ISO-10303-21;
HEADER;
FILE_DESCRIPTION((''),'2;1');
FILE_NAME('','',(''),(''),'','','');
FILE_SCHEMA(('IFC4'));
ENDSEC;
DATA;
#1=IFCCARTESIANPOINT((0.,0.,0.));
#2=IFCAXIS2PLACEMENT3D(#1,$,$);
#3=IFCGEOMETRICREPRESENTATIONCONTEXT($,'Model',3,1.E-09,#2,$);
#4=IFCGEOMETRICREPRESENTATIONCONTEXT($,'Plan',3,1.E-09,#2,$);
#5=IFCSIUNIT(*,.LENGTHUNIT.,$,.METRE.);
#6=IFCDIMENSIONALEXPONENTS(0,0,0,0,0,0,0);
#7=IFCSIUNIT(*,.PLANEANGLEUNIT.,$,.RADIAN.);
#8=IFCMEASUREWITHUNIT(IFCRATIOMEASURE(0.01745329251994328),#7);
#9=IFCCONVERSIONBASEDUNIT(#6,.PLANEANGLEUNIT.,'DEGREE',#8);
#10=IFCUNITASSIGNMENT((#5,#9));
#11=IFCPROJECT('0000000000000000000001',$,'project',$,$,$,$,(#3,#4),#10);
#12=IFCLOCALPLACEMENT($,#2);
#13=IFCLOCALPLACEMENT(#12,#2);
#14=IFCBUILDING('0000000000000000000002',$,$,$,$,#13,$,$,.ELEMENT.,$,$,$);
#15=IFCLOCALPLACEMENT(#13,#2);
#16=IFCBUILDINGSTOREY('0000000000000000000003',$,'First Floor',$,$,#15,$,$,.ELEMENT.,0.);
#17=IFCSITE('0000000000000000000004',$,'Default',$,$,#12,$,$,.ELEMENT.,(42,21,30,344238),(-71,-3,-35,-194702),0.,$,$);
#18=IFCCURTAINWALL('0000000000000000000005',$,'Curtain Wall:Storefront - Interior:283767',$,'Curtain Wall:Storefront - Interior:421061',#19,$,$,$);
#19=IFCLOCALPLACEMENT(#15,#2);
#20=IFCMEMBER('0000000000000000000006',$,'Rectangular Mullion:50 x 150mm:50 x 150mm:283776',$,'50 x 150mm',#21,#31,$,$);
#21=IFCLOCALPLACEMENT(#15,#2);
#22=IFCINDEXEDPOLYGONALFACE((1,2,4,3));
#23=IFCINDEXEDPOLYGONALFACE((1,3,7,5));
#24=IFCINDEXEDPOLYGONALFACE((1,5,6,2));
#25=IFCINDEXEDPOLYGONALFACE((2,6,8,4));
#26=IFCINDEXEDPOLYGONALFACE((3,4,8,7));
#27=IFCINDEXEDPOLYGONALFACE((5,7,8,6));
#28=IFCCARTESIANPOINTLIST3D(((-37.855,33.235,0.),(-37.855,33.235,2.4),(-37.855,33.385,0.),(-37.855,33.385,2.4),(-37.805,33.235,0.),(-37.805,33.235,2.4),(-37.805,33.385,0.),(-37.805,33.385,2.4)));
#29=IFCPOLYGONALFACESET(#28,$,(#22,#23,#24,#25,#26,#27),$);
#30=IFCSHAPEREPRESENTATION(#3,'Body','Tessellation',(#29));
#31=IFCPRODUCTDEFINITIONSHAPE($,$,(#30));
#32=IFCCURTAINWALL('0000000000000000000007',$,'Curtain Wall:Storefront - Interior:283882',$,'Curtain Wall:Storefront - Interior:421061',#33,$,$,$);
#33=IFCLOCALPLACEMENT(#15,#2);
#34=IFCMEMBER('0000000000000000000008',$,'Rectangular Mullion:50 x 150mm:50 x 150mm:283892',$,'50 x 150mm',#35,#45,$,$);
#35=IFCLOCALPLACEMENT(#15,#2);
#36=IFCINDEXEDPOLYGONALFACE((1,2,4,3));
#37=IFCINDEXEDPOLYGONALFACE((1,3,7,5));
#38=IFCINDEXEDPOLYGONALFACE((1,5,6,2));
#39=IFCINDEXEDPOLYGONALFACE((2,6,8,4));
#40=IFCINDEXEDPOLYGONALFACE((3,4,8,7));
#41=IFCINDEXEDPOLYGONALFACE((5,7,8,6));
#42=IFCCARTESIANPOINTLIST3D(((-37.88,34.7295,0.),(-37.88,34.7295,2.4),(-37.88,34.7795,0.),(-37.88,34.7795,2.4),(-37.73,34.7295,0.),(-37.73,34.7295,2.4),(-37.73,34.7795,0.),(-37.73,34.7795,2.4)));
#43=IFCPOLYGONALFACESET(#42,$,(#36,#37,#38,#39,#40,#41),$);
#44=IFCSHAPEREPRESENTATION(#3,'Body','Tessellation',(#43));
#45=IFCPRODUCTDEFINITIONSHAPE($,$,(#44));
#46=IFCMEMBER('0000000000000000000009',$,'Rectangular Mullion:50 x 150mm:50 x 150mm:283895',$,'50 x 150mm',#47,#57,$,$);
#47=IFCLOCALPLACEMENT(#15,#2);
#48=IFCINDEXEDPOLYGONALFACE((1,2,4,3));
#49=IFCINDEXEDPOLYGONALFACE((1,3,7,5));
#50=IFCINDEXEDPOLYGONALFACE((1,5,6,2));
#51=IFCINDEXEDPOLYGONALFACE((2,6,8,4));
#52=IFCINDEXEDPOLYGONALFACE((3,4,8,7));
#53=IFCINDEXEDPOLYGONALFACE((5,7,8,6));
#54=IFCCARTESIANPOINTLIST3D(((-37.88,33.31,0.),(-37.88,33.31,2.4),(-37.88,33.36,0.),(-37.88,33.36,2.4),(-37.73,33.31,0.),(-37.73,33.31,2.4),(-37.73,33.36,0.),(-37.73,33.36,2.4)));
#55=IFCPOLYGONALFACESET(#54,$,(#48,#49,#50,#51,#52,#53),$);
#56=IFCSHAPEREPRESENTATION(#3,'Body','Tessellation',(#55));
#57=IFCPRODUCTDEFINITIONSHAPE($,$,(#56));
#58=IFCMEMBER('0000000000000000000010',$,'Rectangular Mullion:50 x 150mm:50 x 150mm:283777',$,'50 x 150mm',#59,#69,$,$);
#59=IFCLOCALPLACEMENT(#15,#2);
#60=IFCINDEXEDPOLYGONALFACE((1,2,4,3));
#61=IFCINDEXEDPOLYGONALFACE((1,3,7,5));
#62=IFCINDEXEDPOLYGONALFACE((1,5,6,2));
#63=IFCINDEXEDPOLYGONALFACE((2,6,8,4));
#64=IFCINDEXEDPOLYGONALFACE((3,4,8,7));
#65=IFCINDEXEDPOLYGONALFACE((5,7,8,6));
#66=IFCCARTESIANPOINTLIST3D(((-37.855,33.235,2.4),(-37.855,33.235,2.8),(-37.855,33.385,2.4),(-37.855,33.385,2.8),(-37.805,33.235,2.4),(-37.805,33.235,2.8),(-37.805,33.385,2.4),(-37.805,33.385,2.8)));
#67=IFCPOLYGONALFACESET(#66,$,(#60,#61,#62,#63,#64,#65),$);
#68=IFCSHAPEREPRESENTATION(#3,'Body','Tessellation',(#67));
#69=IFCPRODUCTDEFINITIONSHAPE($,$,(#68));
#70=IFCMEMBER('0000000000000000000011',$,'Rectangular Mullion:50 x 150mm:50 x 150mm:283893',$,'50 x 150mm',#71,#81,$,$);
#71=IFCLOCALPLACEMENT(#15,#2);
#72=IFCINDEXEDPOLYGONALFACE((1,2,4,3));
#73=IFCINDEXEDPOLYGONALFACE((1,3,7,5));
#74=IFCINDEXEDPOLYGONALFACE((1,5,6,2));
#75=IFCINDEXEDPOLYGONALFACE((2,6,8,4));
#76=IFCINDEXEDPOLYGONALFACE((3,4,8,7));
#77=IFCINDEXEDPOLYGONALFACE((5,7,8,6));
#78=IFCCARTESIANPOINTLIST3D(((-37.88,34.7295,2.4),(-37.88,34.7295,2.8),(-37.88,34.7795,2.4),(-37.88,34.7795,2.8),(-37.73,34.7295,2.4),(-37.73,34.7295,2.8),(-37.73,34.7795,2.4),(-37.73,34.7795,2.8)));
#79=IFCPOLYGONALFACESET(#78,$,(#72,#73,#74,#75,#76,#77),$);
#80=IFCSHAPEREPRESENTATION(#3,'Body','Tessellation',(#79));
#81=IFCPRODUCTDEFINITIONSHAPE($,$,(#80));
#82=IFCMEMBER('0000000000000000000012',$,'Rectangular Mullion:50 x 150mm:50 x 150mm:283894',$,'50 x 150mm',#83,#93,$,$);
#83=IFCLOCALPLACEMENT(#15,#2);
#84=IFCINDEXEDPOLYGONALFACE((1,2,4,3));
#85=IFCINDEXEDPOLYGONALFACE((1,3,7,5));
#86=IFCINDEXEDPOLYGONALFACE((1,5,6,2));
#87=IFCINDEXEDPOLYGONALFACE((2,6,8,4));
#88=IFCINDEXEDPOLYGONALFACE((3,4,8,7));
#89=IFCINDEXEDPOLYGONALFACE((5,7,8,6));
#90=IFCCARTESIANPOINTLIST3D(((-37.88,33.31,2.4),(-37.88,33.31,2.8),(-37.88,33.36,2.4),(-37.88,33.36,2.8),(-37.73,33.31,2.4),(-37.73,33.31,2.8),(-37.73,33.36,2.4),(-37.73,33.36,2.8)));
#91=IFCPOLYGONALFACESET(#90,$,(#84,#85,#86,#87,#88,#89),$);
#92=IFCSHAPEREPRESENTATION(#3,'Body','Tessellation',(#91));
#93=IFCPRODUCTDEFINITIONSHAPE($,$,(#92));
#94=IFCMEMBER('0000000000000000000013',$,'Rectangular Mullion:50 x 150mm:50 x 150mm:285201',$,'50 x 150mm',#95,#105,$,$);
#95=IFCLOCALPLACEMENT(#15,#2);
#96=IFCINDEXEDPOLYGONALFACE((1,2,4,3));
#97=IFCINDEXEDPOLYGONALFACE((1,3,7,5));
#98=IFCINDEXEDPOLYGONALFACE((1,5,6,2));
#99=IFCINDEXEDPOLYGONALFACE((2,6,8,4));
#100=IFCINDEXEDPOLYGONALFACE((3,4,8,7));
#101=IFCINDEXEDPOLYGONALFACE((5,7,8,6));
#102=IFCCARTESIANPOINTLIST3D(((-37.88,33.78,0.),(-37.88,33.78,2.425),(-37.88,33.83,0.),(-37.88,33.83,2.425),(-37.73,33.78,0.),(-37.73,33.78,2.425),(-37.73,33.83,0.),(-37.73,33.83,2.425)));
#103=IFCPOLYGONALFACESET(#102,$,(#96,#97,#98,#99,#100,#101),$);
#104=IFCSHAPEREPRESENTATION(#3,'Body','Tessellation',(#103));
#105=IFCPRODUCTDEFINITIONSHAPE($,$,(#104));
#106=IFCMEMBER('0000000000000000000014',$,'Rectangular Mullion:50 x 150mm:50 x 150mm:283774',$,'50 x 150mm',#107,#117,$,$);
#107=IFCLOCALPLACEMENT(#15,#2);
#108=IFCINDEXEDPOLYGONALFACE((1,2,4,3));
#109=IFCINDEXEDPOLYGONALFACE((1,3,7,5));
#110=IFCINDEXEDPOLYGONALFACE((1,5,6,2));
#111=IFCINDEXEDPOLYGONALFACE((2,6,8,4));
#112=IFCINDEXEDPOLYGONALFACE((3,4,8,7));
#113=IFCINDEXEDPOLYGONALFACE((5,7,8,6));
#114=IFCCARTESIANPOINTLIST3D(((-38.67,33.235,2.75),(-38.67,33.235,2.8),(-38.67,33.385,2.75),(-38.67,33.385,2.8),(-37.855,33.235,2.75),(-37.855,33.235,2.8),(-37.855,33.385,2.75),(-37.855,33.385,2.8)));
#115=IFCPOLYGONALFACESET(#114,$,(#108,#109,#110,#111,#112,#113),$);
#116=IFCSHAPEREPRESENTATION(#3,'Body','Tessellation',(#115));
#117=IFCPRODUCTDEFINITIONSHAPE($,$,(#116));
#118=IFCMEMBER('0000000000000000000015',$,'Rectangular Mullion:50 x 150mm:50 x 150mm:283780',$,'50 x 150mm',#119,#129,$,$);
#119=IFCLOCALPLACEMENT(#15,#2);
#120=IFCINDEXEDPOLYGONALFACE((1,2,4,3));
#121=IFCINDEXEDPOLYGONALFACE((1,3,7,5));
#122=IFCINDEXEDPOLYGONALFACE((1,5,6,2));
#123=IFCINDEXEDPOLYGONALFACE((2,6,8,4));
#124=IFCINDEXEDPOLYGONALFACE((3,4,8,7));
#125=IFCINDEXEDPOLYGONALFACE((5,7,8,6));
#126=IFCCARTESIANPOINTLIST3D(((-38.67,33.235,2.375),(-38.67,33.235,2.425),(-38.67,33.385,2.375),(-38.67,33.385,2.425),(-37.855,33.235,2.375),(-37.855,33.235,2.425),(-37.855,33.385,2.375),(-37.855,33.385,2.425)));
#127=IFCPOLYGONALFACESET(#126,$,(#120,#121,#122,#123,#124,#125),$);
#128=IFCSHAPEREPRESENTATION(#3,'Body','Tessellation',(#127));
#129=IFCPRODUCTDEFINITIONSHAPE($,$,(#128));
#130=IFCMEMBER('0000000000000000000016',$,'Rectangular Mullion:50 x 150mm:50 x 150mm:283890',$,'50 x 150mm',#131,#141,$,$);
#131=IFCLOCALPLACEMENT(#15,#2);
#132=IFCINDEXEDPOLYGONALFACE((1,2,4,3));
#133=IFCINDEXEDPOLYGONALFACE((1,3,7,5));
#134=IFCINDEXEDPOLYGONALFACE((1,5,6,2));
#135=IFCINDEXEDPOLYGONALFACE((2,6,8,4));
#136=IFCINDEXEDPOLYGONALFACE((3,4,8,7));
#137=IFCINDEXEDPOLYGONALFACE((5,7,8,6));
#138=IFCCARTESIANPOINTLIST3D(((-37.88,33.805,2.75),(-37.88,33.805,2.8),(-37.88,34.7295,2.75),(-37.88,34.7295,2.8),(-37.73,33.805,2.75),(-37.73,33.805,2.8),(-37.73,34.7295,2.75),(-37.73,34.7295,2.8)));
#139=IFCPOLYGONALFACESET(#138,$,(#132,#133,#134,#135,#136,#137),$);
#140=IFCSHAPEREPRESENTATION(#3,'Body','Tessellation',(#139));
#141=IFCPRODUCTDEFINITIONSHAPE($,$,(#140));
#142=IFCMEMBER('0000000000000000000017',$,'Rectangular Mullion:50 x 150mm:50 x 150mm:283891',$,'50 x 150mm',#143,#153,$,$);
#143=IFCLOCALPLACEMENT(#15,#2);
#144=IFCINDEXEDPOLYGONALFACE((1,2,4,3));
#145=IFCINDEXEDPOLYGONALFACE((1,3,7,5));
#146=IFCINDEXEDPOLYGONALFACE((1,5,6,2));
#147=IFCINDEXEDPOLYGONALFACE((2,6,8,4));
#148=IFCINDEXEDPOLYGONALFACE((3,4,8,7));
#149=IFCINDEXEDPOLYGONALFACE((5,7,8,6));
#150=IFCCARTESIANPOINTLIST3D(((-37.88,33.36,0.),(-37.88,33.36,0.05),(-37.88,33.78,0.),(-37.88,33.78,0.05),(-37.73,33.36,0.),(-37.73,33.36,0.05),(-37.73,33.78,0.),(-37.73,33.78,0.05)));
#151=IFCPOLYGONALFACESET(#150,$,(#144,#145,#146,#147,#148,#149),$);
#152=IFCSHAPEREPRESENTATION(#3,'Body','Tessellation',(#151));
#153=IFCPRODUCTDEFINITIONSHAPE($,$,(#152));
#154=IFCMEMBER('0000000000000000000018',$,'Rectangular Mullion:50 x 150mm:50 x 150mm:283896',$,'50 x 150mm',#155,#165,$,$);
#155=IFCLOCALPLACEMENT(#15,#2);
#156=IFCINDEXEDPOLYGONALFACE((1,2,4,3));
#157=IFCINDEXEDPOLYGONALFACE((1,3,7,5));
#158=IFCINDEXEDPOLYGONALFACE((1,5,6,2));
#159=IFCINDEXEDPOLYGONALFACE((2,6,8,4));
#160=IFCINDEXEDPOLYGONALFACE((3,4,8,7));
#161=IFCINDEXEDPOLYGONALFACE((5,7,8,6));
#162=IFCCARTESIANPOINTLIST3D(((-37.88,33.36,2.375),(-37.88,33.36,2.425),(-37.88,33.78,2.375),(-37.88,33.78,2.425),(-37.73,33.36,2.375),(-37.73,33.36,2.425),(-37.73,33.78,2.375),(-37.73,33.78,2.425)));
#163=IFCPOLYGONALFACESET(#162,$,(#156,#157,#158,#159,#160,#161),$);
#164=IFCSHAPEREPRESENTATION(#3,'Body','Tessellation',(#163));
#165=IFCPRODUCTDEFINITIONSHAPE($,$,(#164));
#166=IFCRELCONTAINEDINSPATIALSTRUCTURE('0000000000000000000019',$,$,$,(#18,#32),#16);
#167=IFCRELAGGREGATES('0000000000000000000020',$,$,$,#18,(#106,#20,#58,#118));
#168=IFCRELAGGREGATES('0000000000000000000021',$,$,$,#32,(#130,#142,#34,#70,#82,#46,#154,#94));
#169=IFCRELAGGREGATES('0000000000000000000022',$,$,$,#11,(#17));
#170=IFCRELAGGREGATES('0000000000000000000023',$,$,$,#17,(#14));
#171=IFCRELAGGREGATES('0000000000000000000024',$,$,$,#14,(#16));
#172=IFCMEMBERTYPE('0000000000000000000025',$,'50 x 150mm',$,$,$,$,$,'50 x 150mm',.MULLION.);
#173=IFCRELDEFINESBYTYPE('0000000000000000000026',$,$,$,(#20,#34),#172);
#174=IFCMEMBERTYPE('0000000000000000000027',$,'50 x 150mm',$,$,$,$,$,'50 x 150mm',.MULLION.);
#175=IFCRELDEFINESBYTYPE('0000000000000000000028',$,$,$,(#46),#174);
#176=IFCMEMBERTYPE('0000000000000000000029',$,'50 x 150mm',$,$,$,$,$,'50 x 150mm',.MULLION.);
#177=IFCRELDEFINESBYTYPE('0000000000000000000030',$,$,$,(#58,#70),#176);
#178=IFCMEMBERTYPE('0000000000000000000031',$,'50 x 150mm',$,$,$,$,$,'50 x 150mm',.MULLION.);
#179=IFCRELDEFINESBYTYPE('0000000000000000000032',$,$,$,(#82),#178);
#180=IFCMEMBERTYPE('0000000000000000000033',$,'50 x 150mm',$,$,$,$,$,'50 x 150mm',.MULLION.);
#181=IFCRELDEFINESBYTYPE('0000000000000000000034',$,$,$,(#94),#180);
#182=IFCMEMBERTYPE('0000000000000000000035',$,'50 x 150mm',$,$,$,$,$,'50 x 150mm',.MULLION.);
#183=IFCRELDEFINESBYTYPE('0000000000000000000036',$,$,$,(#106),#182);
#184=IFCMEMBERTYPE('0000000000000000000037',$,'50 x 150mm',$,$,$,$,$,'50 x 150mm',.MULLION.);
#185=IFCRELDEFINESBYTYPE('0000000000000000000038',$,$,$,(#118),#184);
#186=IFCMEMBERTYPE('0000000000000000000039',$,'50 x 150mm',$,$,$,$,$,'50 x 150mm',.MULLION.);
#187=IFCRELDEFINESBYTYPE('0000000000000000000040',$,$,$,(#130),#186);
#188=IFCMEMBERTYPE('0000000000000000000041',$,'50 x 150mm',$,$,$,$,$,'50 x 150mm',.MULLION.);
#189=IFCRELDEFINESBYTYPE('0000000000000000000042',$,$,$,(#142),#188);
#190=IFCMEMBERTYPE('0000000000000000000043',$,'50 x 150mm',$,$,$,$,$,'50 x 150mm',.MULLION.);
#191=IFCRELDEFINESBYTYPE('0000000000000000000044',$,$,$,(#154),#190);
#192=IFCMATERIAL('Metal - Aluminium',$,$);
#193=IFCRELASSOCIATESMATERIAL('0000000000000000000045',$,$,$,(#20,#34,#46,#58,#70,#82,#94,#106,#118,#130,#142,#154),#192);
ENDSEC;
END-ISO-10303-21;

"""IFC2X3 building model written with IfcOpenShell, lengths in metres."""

from ifc_helpers import new_model, entity, si_unit, converted_unit, frame, origin, origin_2d_with_axis, place, context, project, spatial, rectangle, extrude, source, transform, mapped, material, type_object, type_shapes, element, aggregate, save


model = new_model("IFC2X3")

# Units and contexts
model_context = context("Model", 3, precision=1e-09, world=origin())
plan_context = context("Plan", 3, precision=1e-09, world=origin())
ifc_project = project(units=[si_unit("LENGTHUNIT", "METRE"), converted_unit("PLANEANGLEUNIT", "DEGREE", entity("IfcRatioMeasure", 0.01745329251994328), si_unit("PLANEANGLEUNIT", "RADIAN"), dimensions=[0, 0, 0, 0, 0, 0, 0])], contexts=[model_context, plan_context])

# Site, building, storey
site_placement = place(None, origin())
site = spatial("IfcSite", under=ifc_project, at=site_placement, Name="Default", CompositionType="ELEMENT", RefLatitude=(42, 21, 30, 344238), RefLongitude=(-71, -3, -35, -194702), RefElevation=0.0)
building_placement = place(site_placement, origin())
building = spatial("IfcBuilding", under=site, at=building_placement, CompositionType="ELEMENT")
storey_placement = place(building_placement, origin())
storey = spatial("IfcBuildingStorey", under=building, at=storey_placement, Name="First Floor", CompositionType="ELEMENT", Elevation=0.0)

# Curtain wall, member
curtain_wall_1_placement = place(storey_placement, origin())
curtain_wall_1 = element("IfcCurtainWall", 1, at=curtain_wall_1_placement, inside=storey, Name="Curtain Wall:Storefront - Interior:283767", ObjectType="Curtain Wall:Storefront - Interior:421061")
ifc_material_1 = material(Name="Metal - Aluminium")
member_type_1 = type_object("IfcMemberType", Name="50 x 150mm", ElementType="50 x 150mm", PredefinedType="MULLION")
shared_shape_1 = source(origin(), model_context, "Body", "SweptSolid", [
    extrude(rectangle(XDim=0.05, YDim=0.15, at=origin_2d_with_axis()), frame((-0.025, 0.0, -2.4), z_axis=(0.0, 0.0, 1.0), x_axis=(-1.0, 0.0, 0.0)), (0.0, 0.0, 1.0), 2.4),
])
type_shapes(member_type_1, [shared_shape_1])
member_1_placement = place(storey_placement, frame((-37.805, 33.31, 0.0), z_axis=(0.0, 0.0, -1.0), x_axis=(1.0, 0.0, 0.0)))
member_1 = element("IfcMember", 2, at=member_1_placement, type_object=member_type_1, material=ifc_material_1, Name="Rectangular Mullion:50 x 150mm:50 x 150mm:283776", ObjectType="50 x 150mm", context=model_context, shape_type="MappedRepresentation", body=[
    mapped(shared_shape_1, transform((0.0, 0.0, 0.0), scale=1.0)),
])

# Curtain wall, members
curtain_wall_2_placement = place(storey_placement, origin())
curtain_wall_2 = element("IfcCurtainWall", 3, at=curtain_wall_2_placement, inside=storey, Name="Curtain Wall:Storefront - Interior:283882", ObjectType="Curtain Wall:Storefront - Interior:421061")
member_2_placement = place(storey_placement, frame((-37.805, 34.7795, 0.0), z_axis=(0.0, 0.0, -1.0), x_axis=(0.0, 1.0, 0.0)))
member_2 = element("IfcMember", 4, at=member_2_placement, type_object=member_type_1, material=ifc_material_1, Name="Rectangular Mullion:50 x 150mm:50 x 150mm:283892", ObjectType="50 x 150mm", context=model_context, shape_type="MappedRepresentation", body=[
    mapped(shared_shape_1, transform((0.0, 0.0, 0.0), scale=1.0)),
])
member_type_2 = type_object("IfcMemberType", Name="50 x 150mm", ElementType="50 x 150mm", PredefinedType="MULLION")
type_shapes(member_type_2, [shared_shape_1])
member_3_placement = place(storey_placement, frame((-37.805, 33.31, 2.4), z_axis=(0.0, 0.0, 1.0), x_axis=(0.0, -1.0, 0.0)))
member_3 = element("IfcMember", 5, at=member_3_placement, type_object=member_type_2, material=ifc_material_1, Name="Rectangular Mullion:50 x 150mm:50 x 150mm:283895", ObjectType="50 x 150mm", context=model_context, shape_type="MappedRepresentation", body=[
    mapped(shared_shape_1, transform((0.0, 0.0, 0.0), scale=1.0)),
])

# Members
member_type_3 = type_object("IfcMemberType", Name="50 x 150mm", ElementType="50 x 150mm", PredefinedType="MULLION")
shared_shape_2 = source(origin(), model_context, "Body", "SweptSolid", [
    extrude(rectangle(XDim=0.05, YDim=0.15, at=origin_2d_with_axis()), frame((-0.025, 0.0, -0.4), z_axis=(0.0, 0.0, 1.0), x_axis=(-1.0, 0.0, 0.0)), (0.0, 0.0, 1.0), 0.4),
])
type_shapes(member_type_3, [shared_shape_2])
member_4_placement = place(storey_placement, frame((-37.805, 33.31, 2.4), z_axis=(0.0, 0.0, -1.0), x_axis=(1.0, 0.0, 0.0)))
member_4 = element("IfcMember", 6, at=member_4_placement, type_object=member_type_3, material=ifc_material_1, Name="Rectangular Mullion:50 x 150mm:50 x 150mm:283777", ObjectType="50 x 150mm", context=model_context, shape_type="MappedRepresentation", body=[
    mapped(shared_shape_2, transform((0.0, 0.0, 0.0), scale=1.0)),
])
member_5_placement = place(storey_placement, frame((-37.805, 34.7795, 2.4), z_axis=(0.0, 0.0, -1.0), x_axis=(0.0, 1.0, 0.0)))
member_5 = element("IfcMember", 7, at=member_5_placement, type_object=member_type_3, material=ifc_material_1, Name="Rectangular Mullion:50 x 150mm:50 x 150mm:283893", ObjectType="50 x 150mm", context=model_context, shape_type="MappedRepresentation", body=[
    mapped(shared_shape_2, transform((0.0, 0.0, 0.0), scale=1.0)),
])
member_type_4 = type_object("IfcMemberType", Name="50 x 150mm", ElementType="50 x 150mm", PredefinedType="MULLION")
type_shapes(member_type_4, [shared_shape_2])
member_6_placement = place(storey_placement, frame((-37.805, 33.31, 2.8), z_axis=(0.0, 0.0, 1.0), x_axis=(0.0, -1.0, 0.0)))
member_6 = element("IfcMember", 8, at=member_6_placement, type_object=member_type_4, material=ifc_material_1, Name="Rectangular Mullion:50 x 150mm:50 x 150mm:283894", ObjectType="50 x 150mm", context=model_context, shape_type="MappedRepresentation", body=[
    mapped(shared_shape_2, transform((0.0, 0.0, 0.0), scale=1.0)),
])
member_type_5 = type_object("IfcMemberType", Name="50 x 150mm", ElementType="50 x 150mm", PredefinedType="MULLION")
shared_shape_3 = source(origin(), model_context, "Body", "SweptSolid", [
    extrude(rectangle(XDim=0.05, YDim=0.15, at=origin_2d_with_axis()), frame((0.0, 0.0, -2.425), z_axis=(0.0, 0.0, 1.0), x_axis=(-1.0, 0.0, 0.0)), (0.0, 0.0, 1.0), 2.425),
])
type_shapes(member_type_5, [shared_shape_3])
member_7_placement = place(storey_placement, frame((-37.805, 33.805, 0.0), z_axis=(0.0, 0.0, -1.0), x_axis=(0.0, 1.0, 0.0)))
member_7 = element("IfcMember", 9, at=member_7_placement, type_object=member_type_5, material=ifc_material_1, Name="Rectangular Mullion:50 x 150mm:50 x 150mm:285201", ObjectType="50 x 150mm", context=model_context, shape_type="MappedRepresentation", body=[
    mapped(shared_shape_3, transform((0.0, 0.0, 0.0), scale=1.0)),
])
member_type_6 = type_object("IfcMemberType", Name="50 x 150mm", ElementType="50 x 150mm", PredefinedType="MULLION")
shared_shape_4 = source(origin(), model_context, "Body", "SweptSolid", [
    extrude(rectangle(XDim=0.05, YDim=0.15, at=origin_2d_with_axis()), frame((-0.025, 0.0, -0.815), z_axis=(0.0, 0.0, 1.0), x_axis=(-1.0, 0.0, 0.0)), (0.0, 0.0, 1.0), 0.815),
])
type_shapes(member_type_6, [shared_shape_4])
member_8_placement = place(storey_placement, frame((-37.855, 33.31, 2.8), z_axis=(1.0, 0.0, 0.0), x_axis=(0.0, 0.0, 1.0)))
member_8 = element("IfcMember", 10, at=member_8_placement, type_object=member_type_6, material=ifc_material_1, Name="Rectangular Mullion:50 x 150mm:50 x 150mm:283774", ObjectType="50 x 150mm", context=model_context, shape_type="MappedRepresentation", body=[
    mapped(shared_shape_4, transform((0.0, 0.0, 0.0), scale=1.0)),
])
member_type_7 = type_object("IfcMemberType", Name="50 x 150mm", ElementType="50 x 150mm", PredefinedType="MULLION")
shared_shape_5 = source(origin(), model_context, "Body", "SweptSolid", [
    extrude(rectangle(XDim=0.05, YDim=0.15, at=origin_2d_with_axis()), frame((0.0, 0.0, -0.815), z_axis=(0.0, 0.0, 1.0), x_axis=(-1.0, 0.0, 0.0)), (0.0, 0.0, 1.0), 0.815),
])
type_shapes(member_type_7, [shared_shape_5])
member_9_placement = place(storey_placement, frame((-37.855, 33.31, 2.4), z_axis=(1.0, 0.0, 0.0), x_axis=(0.0, 0.0, 1.0)))
member_9 = element("IfcMember", 11, at=member_9_placement, type_object=member_type_7, material=ifc_material_1, Name="Rectangular Mullion:50 x 150mm:50 x 150mm:283780", ObjectType="50 x 150mm", context=model_context, shape_type="MappedRepresentation", body=[
    mapped(shared_shape_5, transform((0.0, 0.0, 0.0), scale=1.0)),
])
member_type_8 = type_object("IfcMemberType", Name="50 x 150mm", ElementType="50 x 150mm", PredefinedType="MULLION")
shared_shape_6 = source(origin(), model_context, "Body", "SweptSolid", [
    extrude(rectangle(XDim=0.05, YDim=0.15, at=origin_2d_with_axis()), frame((-0.025, 0.0, -0.9245), z_axis=(0.0, 0.0, 1.0), x_axis=(-1.0, 0.0, 0.0)), (0.0, 0.0, 1.0), 0.9245),
])
type_shapes(member_type_8, [shared_shape_6])
member_10_placement = place(storey_placement, frame((-37.805, 34.7295, 2.8), z_axis=(0.0, 1.0, 0.0), x_axis=(0.0, 0.0, 1.0)))
member_10 = element("IfcMember", 12, at=member_10_placement, type_object=member_type_8, material=ifc_material_1, Name="Rectangular Mullion:50 x 150mm:50 x 150mm:283890", ObjectType="50 x 150mm", context=model_context, shape_type="MappedRepresentation", body=[
    mapped(shared_shape_6, transform((0.0, 0.0, 0.0), scale=1.0)),
])
member_type_9 = type_object("IfcMemberType", Name="50 x 150mm", ElementType="50 x 150mm", PredefinedType="MULLION")
shared_shape_7 = source(origin(), model_context, "Body", "SweptSolid", [
    extrude(rectangle(XDim=0.05, YDim=0.15, at=origin_2d_with_axis()), frame((-0.025, 0.0, -0.42), z_axis=(0.0, 0.0, 1.0), x_axis=(-1.0, 0.0, 0.0)), (0.0, 0.0, 1.0), 0.42),
])
type_shapes(member_type_9, [shared_shape_7])
member_11_placement = place(storey_placement, frame((-37.805, 33.36, 0.0), z_axis=(0.0, -1.0, 0.0), x_axis=(0.0, 0.0, -1.0)))
member_11 = element("IfcMember", 13, at=member_11_placement, type_object=member_type_9, material=ifc_material_1, Name="Rectangular Mullion:50 x 150mm:50 x 150mm:283891", ObjectType="50 x 150mm", context=model_context, shape_type="MappedRepresentation", body=[
    mapped(shared_shape_7, transform((0.0, 0.0, 0.0), scale=1.0)),
])
member_type_10 = type_object("IfcMemberType", Name="50 x 150mm", ElementType="50 x 150mm", PredefinedType="MULLION")
shared_shape_8 = source(origin(), model_context, "Body", "SweptSolid", [
    extrude(rectangle(XDim=0.05, YDim=0.15, at=origin_2d_with_axis()), frame((0.0, 0.0, -0.42), z_axis=(0.0, 0.0, 1.0), x_axis=(-1.0, 0.0, 0.0)), (0.0, 0.0, 1.0), 0.42),
])
type_shapes(member_type_10, [shared_shape_8])
member_12_placement = place(storey_placement, frame((-37.805, 33.78, 2.4), z_axis=(0.0, 1.0, 0.0), x_axis=(0.0, 0.0, 1.0)))
member_12 = element("IfcMember", 14, at=member_12_placement, type_object=member_type_10, material=ifc_material_1, Name="Rectangular Mullion:50 x 150mm:50 x 150mm:283896", ObjectType="50 x 150mm", context=model_context, shape_type="MappedRepresentation", body=[
    mapped(shared_shape_8, transform((0.0, 0.0, 0.0), scale=1.0)),
])

aggregate(curtain_wall_1, [member_8, member_1, member_4, member_9])

aggregate(curtain_wall_2, [member_10, member_11, member_2, member_5, member_6, member_3, member_12, member_7])

save(model, "model.ifc")
